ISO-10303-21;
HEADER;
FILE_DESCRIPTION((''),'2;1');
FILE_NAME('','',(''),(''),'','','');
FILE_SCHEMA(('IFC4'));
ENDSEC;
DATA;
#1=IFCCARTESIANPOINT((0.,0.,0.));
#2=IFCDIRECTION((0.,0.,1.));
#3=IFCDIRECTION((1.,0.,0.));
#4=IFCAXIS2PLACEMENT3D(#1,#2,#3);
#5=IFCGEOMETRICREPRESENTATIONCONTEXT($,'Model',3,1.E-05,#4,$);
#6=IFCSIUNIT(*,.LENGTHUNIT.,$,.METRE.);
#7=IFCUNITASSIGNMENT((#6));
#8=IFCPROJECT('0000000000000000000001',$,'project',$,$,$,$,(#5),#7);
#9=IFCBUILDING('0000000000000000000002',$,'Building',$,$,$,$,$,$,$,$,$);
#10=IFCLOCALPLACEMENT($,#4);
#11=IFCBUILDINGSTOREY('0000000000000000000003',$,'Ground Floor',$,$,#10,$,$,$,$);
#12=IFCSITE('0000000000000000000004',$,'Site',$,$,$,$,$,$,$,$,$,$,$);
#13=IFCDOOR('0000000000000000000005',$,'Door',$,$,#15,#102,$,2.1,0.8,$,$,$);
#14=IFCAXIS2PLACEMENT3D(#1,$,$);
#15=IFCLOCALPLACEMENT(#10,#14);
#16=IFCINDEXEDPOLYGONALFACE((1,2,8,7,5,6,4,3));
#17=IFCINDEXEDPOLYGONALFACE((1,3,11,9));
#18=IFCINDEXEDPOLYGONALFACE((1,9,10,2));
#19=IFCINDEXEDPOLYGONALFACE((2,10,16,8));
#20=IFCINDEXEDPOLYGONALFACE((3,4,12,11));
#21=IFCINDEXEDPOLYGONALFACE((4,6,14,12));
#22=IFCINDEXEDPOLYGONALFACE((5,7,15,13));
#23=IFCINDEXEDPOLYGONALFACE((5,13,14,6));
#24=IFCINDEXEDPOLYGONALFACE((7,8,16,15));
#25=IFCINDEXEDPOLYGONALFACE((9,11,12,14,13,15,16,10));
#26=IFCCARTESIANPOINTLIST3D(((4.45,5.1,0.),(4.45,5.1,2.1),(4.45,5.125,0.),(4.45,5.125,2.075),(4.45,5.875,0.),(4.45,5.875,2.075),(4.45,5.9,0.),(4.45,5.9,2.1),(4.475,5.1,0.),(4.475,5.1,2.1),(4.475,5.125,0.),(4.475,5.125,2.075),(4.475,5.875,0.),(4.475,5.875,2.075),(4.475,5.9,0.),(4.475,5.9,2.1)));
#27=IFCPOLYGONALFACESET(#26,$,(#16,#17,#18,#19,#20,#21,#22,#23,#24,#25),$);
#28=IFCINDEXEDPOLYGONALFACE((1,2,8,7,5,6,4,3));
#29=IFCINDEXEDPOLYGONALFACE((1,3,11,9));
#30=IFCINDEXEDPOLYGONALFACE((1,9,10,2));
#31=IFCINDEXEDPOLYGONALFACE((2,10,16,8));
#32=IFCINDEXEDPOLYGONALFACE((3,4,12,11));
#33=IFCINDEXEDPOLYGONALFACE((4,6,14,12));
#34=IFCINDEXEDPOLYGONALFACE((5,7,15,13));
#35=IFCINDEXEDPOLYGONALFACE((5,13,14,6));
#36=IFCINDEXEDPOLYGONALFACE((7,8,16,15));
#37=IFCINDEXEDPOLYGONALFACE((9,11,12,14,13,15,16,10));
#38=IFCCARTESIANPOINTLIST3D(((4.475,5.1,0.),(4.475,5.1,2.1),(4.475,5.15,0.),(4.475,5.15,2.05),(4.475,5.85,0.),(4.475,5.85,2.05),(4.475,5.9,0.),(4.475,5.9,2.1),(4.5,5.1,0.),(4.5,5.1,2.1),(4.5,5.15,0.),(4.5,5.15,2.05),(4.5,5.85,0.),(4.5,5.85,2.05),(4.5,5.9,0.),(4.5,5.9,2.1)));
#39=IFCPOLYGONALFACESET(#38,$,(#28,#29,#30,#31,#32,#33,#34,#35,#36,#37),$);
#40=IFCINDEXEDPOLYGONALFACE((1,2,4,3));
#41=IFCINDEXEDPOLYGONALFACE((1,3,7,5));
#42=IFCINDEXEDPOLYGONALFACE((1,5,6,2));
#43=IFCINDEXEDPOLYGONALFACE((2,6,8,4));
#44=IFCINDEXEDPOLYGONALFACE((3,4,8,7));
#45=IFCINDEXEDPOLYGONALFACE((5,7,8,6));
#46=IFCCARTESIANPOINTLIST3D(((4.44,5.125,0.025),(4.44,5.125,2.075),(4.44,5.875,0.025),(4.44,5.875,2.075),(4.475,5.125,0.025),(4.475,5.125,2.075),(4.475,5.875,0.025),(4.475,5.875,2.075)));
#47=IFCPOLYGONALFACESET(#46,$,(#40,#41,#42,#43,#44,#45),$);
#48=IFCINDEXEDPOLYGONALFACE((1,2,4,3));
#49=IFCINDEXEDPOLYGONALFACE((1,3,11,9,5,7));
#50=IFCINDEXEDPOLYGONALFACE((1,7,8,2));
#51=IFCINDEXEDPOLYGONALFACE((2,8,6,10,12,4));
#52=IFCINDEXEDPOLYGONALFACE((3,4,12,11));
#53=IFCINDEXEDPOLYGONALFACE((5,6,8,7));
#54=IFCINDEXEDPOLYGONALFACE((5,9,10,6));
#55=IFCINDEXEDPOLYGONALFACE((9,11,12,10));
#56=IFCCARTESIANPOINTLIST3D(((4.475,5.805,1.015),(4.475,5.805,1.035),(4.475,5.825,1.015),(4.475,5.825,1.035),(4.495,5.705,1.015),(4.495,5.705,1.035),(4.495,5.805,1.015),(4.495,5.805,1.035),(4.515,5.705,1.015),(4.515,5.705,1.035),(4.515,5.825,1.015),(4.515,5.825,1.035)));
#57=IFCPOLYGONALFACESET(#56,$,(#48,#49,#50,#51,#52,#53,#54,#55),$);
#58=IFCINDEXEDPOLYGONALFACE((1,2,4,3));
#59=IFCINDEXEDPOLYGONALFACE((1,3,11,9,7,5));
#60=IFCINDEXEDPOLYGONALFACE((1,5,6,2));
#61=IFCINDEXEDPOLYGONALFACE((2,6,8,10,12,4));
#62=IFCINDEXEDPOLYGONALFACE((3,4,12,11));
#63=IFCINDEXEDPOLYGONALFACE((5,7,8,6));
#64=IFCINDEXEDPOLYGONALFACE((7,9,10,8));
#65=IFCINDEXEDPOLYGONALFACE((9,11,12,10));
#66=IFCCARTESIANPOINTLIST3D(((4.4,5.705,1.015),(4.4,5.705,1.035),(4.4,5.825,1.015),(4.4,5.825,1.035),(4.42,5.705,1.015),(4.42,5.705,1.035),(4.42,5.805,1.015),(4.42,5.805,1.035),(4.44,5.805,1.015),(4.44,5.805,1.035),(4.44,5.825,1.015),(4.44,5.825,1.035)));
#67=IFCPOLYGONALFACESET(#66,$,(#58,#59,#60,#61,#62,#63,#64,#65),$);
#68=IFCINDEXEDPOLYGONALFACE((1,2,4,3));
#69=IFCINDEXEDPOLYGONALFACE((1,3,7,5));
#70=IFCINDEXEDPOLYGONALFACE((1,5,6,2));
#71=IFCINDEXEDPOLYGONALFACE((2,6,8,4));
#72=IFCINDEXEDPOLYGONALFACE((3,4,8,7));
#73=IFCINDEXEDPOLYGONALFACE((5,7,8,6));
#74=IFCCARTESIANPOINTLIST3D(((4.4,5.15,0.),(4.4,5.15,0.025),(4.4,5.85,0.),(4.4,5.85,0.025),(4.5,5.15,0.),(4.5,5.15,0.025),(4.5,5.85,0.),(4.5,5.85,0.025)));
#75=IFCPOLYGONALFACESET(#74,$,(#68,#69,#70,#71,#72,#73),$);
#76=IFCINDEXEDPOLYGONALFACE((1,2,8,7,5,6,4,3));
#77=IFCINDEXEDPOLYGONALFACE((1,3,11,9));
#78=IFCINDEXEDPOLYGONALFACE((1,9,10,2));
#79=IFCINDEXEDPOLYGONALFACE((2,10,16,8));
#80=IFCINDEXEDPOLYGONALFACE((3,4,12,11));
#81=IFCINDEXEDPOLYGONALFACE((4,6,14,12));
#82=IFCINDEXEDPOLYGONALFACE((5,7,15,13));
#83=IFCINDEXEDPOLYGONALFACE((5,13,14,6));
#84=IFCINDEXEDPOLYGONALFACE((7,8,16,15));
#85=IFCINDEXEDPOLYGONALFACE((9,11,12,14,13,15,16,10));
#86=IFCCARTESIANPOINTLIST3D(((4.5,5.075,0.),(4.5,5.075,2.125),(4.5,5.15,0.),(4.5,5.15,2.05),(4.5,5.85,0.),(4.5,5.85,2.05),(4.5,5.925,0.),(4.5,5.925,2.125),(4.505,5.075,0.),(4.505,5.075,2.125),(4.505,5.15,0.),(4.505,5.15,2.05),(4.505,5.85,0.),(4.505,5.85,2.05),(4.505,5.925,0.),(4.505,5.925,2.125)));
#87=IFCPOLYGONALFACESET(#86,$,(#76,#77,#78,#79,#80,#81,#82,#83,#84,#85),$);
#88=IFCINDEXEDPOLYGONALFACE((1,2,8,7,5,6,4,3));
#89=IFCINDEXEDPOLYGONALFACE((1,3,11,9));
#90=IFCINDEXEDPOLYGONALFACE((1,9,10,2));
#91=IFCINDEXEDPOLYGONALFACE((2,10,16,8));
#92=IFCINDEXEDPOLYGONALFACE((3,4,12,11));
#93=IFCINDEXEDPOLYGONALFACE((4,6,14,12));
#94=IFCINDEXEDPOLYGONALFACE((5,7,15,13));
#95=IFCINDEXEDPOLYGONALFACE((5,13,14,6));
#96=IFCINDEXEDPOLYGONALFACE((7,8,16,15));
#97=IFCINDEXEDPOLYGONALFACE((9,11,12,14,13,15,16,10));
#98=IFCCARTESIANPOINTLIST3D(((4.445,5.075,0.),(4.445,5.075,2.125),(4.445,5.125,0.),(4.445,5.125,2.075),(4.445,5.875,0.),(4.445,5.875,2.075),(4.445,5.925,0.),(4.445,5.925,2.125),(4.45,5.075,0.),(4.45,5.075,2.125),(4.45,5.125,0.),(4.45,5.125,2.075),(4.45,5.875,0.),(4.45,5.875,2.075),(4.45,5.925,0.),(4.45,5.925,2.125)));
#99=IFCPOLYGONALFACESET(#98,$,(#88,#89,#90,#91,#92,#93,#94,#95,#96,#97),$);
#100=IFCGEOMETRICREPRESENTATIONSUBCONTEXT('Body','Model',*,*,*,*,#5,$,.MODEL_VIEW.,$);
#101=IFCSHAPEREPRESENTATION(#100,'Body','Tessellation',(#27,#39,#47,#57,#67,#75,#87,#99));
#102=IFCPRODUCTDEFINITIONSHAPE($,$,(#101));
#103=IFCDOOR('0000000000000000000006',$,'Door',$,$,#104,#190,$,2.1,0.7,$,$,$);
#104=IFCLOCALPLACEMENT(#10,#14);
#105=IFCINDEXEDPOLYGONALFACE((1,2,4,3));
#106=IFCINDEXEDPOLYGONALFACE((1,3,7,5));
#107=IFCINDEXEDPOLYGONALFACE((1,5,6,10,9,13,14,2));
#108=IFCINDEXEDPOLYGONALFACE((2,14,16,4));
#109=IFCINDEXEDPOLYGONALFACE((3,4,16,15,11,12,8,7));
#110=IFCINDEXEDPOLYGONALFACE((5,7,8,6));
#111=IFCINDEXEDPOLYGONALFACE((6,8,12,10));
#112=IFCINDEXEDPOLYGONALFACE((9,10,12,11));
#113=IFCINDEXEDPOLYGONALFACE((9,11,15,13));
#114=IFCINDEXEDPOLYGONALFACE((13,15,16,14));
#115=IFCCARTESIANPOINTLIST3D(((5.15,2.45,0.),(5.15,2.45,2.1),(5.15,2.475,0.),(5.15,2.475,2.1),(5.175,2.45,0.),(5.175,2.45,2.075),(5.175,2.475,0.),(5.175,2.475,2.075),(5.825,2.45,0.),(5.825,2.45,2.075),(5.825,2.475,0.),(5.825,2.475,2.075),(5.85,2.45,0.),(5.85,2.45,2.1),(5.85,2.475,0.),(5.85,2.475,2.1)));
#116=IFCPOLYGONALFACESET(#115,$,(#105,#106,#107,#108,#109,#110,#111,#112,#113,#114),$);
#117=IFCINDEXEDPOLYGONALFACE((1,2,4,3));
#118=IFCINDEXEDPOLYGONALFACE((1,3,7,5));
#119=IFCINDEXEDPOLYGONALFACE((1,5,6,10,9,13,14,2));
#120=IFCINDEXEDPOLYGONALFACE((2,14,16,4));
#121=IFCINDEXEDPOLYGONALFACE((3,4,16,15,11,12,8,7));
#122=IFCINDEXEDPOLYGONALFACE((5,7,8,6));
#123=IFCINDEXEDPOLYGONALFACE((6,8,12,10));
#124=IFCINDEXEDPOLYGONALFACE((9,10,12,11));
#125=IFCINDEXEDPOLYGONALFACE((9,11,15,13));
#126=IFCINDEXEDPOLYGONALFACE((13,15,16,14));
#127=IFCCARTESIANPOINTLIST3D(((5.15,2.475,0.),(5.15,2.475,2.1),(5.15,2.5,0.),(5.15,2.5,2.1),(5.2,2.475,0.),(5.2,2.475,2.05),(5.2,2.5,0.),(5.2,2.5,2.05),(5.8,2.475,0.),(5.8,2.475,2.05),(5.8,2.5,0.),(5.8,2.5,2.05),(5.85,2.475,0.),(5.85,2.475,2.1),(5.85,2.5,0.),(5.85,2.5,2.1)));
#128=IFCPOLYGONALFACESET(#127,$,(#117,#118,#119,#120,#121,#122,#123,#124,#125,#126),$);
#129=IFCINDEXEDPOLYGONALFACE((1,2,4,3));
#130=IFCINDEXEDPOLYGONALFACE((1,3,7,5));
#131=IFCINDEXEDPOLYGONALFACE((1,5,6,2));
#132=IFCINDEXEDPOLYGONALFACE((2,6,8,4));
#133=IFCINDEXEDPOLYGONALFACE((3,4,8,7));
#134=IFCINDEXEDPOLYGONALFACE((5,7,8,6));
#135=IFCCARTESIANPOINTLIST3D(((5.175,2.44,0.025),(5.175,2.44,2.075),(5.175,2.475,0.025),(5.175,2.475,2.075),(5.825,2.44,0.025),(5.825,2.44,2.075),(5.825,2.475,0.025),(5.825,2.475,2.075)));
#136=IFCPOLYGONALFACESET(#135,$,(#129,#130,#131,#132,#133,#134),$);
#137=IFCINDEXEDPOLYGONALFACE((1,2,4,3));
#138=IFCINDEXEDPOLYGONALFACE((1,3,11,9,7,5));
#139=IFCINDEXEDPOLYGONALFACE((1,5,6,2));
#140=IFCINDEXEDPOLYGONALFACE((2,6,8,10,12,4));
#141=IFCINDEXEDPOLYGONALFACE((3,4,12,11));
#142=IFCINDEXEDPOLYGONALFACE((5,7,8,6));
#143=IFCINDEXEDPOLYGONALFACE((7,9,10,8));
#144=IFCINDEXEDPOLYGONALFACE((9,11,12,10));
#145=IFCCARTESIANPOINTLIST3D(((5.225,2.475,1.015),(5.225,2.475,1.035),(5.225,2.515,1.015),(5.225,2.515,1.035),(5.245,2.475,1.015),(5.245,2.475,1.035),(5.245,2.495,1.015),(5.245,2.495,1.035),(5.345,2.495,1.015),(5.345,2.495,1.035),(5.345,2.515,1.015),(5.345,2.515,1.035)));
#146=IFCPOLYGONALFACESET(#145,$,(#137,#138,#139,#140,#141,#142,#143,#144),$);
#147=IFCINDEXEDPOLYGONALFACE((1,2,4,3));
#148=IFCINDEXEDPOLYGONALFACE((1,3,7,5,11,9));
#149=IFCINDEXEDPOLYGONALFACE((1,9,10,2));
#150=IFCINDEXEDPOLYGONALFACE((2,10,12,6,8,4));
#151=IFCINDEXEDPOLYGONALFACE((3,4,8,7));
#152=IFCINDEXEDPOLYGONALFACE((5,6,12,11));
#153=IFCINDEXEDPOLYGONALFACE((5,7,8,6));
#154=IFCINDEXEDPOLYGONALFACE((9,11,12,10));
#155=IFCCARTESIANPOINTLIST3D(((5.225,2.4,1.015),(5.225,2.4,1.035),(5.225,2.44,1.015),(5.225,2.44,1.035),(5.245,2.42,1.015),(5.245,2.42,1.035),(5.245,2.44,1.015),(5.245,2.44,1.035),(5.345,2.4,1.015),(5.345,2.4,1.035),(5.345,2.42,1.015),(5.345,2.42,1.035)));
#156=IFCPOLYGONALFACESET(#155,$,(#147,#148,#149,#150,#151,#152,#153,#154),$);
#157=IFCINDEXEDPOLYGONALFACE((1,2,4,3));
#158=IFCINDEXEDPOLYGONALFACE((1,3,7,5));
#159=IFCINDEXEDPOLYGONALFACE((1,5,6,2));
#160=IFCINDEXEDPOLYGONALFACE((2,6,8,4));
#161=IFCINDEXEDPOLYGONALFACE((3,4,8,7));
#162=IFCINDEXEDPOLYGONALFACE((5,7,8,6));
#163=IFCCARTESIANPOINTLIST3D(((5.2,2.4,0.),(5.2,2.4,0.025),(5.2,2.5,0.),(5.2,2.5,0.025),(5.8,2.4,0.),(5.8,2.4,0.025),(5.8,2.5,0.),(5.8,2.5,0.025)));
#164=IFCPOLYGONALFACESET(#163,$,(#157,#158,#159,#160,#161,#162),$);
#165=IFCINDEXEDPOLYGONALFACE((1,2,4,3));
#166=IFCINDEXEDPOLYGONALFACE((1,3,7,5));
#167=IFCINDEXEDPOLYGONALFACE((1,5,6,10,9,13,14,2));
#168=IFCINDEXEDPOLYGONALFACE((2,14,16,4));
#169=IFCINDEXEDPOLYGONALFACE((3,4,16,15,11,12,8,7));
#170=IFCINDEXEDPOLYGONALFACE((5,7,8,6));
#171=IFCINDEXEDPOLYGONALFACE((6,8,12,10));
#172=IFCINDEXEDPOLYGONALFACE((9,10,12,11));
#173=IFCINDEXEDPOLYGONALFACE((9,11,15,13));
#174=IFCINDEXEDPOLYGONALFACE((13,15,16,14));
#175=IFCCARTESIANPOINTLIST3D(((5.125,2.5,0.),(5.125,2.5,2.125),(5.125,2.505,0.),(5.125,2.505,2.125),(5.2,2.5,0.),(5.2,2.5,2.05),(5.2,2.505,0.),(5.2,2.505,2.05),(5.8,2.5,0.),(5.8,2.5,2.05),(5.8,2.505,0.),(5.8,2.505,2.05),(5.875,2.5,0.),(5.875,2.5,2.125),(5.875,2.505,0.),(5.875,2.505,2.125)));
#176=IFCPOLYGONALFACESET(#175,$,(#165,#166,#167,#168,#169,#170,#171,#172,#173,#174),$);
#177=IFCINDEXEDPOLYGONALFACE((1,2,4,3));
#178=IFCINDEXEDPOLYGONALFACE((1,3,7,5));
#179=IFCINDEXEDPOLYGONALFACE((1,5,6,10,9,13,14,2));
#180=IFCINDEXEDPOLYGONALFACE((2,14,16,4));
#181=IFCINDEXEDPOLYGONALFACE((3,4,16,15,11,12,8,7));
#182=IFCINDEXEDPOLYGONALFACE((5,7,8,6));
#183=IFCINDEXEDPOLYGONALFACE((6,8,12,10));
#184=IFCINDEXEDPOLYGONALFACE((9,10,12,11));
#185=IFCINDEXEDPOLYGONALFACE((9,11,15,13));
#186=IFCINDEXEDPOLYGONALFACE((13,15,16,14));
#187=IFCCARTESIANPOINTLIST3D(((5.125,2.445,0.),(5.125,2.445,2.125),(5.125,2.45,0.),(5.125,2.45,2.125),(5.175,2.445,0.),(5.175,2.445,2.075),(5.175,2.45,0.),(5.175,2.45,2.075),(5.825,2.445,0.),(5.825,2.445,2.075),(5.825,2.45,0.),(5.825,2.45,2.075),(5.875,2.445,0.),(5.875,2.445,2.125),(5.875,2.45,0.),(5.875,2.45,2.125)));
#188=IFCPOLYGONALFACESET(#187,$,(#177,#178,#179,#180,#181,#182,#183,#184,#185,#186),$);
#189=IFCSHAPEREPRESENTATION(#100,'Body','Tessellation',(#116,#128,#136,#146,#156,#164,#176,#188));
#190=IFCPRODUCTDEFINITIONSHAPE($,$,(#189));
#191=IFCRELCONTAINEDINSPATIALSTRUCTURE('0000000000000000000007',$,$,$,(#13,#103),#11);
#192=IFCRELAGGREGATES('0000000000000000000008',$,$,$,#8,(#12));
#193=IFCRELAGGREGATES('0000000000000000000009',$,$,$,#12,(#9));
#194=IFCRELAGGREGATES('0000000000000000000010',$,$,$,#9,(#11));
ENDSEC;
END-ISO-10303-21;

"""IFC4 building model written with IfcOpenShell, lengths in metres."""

from ifc_helpers import new_model, si_unit, frame, origin_with_axes, place, context, subcontext, project, spatial, line, indexed_curve, outline, extrude, element, save


model = new_model("IFC4")

# Units and contexts
model_context = context("Model", 3, precision=1e-05, world=origin_with_axes())
body_context = subcontext(model_context, "Body", "Model", "MODEL_VIEW")
ifc_project = project(units=[si_unit("LENGTHUNIT", "METRE")], contexts=[model_context])

# Site, building, storey
site = spatial("IfcSite", under=ifc_project, Name="Site")
building = spatial("IfcBuilding", under=site, Name="Building")
storey_placement = place(None, origin_with_axes())
storey = spatial("IfcBuildingStorey", under=building, at=storey_placement, Name="Ground Floor")

# Doors
door_1_placement = place(storey_placement, frame((4.5, 5.1, 0.0), z_axis=(0.0, 0.0, 1.0), x_axis=(0.0, 1.0, 0.0)))
element("IfcDoor", 1, at=door_1_placement, inside=storey, Name="Door", OverallHeight=2.1, OverallWidth=0.8, context=body_context, shape_type="SweptSolid", body=[
    extrude(outline(indexed_curve([(0.0, 0.0), (0.0, 2.1), (0.8, 2.1), (0.8, 0.0), (0.775, 0.0), (0.775, 2.075), (0.025, 2.075), (0.025, 0.0)], segments=[line(1, 2, 3, 4, 5, 6, 7, 8, 1)])), frame((0.0, 0.025, 0.0), z_axis=(0.0, -1.0, 0.0), x_axis=(1.0, 0.0, 0.0)), (0.0, 0.0, -1.0), 0.025),
    extrude(outline(indexed_curve([(0.0, 0.0), (0.0, 2.1), (0.8, 2.1), (0.8, 0.0), (0.75, 0.0), (0.75, 2.05), (0.05, 2.05), (0.05, 0.0)], segments=[line(1, 2, 3, 4, 5, 6, 7, 8, 1)])), frame((0.0, 0.0, 0.0), z_axis=(0.0, -1.0, 0.0), x_axis=(1.0, 0.0, 0.0)), (0.0, 0.0, -1.0), 0.025),
    extrude(outline(indexed_curve([(0.0, 0.0), (0.75, 0.0), (0.75, 0.035), (0.0, 0.035)], segments=[line(1, 2, 3, 4, 1)])), frame((0.025, 0.025, 0.025), z_axis=(0.0, 0.0, 1.0), x_axis=(1.0, 0.0, 0.0)), (0.0, 0.0, 1.0), 2.05),
    extrude(outline(indexed_curve([(0.0, 0.0), (0.0, -0.04), (-0.12, -0.04), (-0.12, -0.02), (-0.02, -0.02), (-0.02, 0.0)], segments=[line(1, 2, 3, 4, 5, 6, 1)])), frame((0.725, 0.025, 1.015), z_axis=(0.0, 0.0, 1.0), x_axis=(1.0, 0.0, 0.0)), (0.0, 0.0, 1.0), 0.02),
    extrude(outline(indexed_curve([(0.0, 0.0), (0.0, 0.04), (-0.12, 0.04), (-0.12, 0.02), (-0.02, 0.02), (-0.02, 0.0)], segments=[line(1, 2, 3, 4, 5, 6, 1)])), frame((0.725, 0.06, 1.015), z_axis=(0.0, 0.0, 1.0), x_axis=(1.0, 0.0, 0.0)), (0.0, 0.0, 1.0), 0.02),
    extrude(outline(indexed_curve([(0.0, 0.0), (0.7, 0.0), (0.7, 0.1), (0.0, 0.1)], segments=[line(1, 2, 3, 4, 1)])), frame((0.05, 0.0, 0.0), z_axis=(0.0, 0.0, 1.0), x_axis=(1.0, 0.0, 0.0)), (0.0, 0.0, 1.0), 0.025),
    extrude(outline(indexed_curve([(0.0, 0.0), (0.0, 2.125), (0.85, 2.125), (0.85, 0.0), (0.775, 0.0), (0.775, 2.05), (0.075, 2.05), (0.075, 0.0)], segments=[line(1, 2, 3, 4, 5, 6, 7, 8, 1)])), frame((-0.025, -0.005, 0.0), z_axis=(0.0, -1.0, 0.0), x_axis=(1.0, 0.0, 0.0)), (0.0, 0.0, -1.0), 0.005),
    extrude(outline(indexed_curve([(0.0, 0.0), (0.0, 2.125), (0.85, 2.125), (0.85, 0.0), (0.8, 0.0), (0.8, 2.075), (0.05, 2.075), (0.05, 0.0)], segments=[line(1, 2, 3, 4, 5, 6, 7, 8, 1)])), frame((-0.025, 0.05, 0.0), z_axis=(0.0, -1.0, 0.0), x_axis=(1.0, 0.0, 0.0)), (0.0, 0.0, -1.0), 0.005),
])
door_2_placement = place(storey_placement, frame((5.85, 2.5, 0.0), z_axis=(0.0, 0.0, 1.0), x_axis=(-1.0, 0.0, 0.0)))
element("IfcDoor", 2, at=door_2_placement, inside=storey, Name="Door", OverallHeight=2.1, OverallWidth=0.7, context=body_context, shape_type="SweptSolid", body=[
    extrude(outline(indexed_curve([(0.0, 0.0), (0.0, 2.1), (0.7, 2.1), (0.7, 0.0), (0.675, 0.0), (0.675, 2.075), (0.025, 2.075), (0.025, 0.0)], segments=[line(1, 2, 3, 4, 5, 6, 7, 8, 1)])), frame((0.0, 0.025, 0.0), z_axis=(0.0, -1.0, 0.0), x_axis=(1.0, 0.0, 0.0)), (0.0, 0.0, -1.0), 0.025),
    extrude(outline(indexed_curve([(0.0, 0.0), (0.0, 2.1), (0.7, 2.1), (0.7, 0.0), (0.65, 0.0), (0.65, 2.05), (0.05, 2.05), (0.05, 0.0)], segments=[line(1, 2, 3, 4, 5, 6, 7, 8, 1)])), frame((0.0, 0.0, 0.0), z_axis=(0.0, -1.0, 0.0), x_axis=(1.0, 0.0, 0.0)), (0.0, 0.0, -1.0), 0.025),
    extrude(outline(indexed_curve([(0.0, 0.0), (0.65, 0.0), (0.65, 0.035), (0.0, 0.035)], segments=[line(1, 2, 3, 4, 1)])), frame((0.025, 0.025, 0.025), z_axis=(0.0, 0.0, 1.0), x_axis=(1.0, 0.0, 0.0)), (0.0, 0.0, 1.0), 2.05),
    extrude(outline(indexed_curve([(0.0, 0.0), (0.0, -0.04), (-0.12, -0.04), (-0.12, -0.02), (-0.02, -0.02), (-0.02, 0.0)], segments=[line(1, 2, 3, 4, 5, 6, 1)])), frame((0.625, 0.025, 1.015), z_axis=(0.0, 0.0, 1.0), x_axis=(1.0, 0.0, 0.0)), (0.0, 0.0, 1.0), 0.02),
    extrude(outline(indexed_curve([(0.0, 0.0), (0.0, 0.04), (-0.12, 0.04), (-0.12, 0.02), (-0.02, 0.02), (-0.02, 0.0)], segments=[line(1, 2, 3, 4, 5, 6, 1)])), frame((0.625, 0.06, 1.015), z_axis=(0.0, 0.0, 1.0), x_axis=(1.0, 0.0, 0.0)), (0.0, 0.0, 1.0), 0.02),
    extrude(outline(indexed_curve([(0.0, 0.0), (0.6, 0.0), (0.6, 0.1), (0.0, 0.1)], segments=[line(1, 2, 3, 4, 1)])), frame((0.05, 0.0, 0.0), z_axis=(0.0, 0.0, 1.0), x_axis=(1.0, 0.0, 0.0)), (0.0, 0.0, 1.0), 0.025),
    extrude(outline(indexed_curve([(0.0, 0.0), (0.0, 2.125), (0.75, 2.125), (0.75, 0.0), (0.675, 0.0), (0.675, 2.05), (0.075, 2.05), (0.075, 0.0)], segments=[line(1, 2, 3, 4, 5, 6, 7, 8, 1)])), frame((-0.025, -0.005, 0.0), z_axis=(0.0, -1.0, 0.0), x_axis=(1.0, 0.0, 0.0)), (0.0, 0.0, -1.0), 0.005),
    extrude(outline(indexed_curve([(0.0, 0.0), (0.0, 2.125), (0.75, 2.125), (0.75, 0.0), (0.7, 0.0), (0.7, 2.075), (0.05, 2.075), (0.05, 0.0)], segments=[line(1, 2, 3, 4, 5, 6, 7, 8, 1)])), frame((-0.025, 0.05, 0.0), z_axis=(0.0, -1.0, 0.0), x_axis=(1.0, 0.0, 0.0)), (0.0, 0.0, -1.0), 0.005),
])

save(model, "model.ifc")
